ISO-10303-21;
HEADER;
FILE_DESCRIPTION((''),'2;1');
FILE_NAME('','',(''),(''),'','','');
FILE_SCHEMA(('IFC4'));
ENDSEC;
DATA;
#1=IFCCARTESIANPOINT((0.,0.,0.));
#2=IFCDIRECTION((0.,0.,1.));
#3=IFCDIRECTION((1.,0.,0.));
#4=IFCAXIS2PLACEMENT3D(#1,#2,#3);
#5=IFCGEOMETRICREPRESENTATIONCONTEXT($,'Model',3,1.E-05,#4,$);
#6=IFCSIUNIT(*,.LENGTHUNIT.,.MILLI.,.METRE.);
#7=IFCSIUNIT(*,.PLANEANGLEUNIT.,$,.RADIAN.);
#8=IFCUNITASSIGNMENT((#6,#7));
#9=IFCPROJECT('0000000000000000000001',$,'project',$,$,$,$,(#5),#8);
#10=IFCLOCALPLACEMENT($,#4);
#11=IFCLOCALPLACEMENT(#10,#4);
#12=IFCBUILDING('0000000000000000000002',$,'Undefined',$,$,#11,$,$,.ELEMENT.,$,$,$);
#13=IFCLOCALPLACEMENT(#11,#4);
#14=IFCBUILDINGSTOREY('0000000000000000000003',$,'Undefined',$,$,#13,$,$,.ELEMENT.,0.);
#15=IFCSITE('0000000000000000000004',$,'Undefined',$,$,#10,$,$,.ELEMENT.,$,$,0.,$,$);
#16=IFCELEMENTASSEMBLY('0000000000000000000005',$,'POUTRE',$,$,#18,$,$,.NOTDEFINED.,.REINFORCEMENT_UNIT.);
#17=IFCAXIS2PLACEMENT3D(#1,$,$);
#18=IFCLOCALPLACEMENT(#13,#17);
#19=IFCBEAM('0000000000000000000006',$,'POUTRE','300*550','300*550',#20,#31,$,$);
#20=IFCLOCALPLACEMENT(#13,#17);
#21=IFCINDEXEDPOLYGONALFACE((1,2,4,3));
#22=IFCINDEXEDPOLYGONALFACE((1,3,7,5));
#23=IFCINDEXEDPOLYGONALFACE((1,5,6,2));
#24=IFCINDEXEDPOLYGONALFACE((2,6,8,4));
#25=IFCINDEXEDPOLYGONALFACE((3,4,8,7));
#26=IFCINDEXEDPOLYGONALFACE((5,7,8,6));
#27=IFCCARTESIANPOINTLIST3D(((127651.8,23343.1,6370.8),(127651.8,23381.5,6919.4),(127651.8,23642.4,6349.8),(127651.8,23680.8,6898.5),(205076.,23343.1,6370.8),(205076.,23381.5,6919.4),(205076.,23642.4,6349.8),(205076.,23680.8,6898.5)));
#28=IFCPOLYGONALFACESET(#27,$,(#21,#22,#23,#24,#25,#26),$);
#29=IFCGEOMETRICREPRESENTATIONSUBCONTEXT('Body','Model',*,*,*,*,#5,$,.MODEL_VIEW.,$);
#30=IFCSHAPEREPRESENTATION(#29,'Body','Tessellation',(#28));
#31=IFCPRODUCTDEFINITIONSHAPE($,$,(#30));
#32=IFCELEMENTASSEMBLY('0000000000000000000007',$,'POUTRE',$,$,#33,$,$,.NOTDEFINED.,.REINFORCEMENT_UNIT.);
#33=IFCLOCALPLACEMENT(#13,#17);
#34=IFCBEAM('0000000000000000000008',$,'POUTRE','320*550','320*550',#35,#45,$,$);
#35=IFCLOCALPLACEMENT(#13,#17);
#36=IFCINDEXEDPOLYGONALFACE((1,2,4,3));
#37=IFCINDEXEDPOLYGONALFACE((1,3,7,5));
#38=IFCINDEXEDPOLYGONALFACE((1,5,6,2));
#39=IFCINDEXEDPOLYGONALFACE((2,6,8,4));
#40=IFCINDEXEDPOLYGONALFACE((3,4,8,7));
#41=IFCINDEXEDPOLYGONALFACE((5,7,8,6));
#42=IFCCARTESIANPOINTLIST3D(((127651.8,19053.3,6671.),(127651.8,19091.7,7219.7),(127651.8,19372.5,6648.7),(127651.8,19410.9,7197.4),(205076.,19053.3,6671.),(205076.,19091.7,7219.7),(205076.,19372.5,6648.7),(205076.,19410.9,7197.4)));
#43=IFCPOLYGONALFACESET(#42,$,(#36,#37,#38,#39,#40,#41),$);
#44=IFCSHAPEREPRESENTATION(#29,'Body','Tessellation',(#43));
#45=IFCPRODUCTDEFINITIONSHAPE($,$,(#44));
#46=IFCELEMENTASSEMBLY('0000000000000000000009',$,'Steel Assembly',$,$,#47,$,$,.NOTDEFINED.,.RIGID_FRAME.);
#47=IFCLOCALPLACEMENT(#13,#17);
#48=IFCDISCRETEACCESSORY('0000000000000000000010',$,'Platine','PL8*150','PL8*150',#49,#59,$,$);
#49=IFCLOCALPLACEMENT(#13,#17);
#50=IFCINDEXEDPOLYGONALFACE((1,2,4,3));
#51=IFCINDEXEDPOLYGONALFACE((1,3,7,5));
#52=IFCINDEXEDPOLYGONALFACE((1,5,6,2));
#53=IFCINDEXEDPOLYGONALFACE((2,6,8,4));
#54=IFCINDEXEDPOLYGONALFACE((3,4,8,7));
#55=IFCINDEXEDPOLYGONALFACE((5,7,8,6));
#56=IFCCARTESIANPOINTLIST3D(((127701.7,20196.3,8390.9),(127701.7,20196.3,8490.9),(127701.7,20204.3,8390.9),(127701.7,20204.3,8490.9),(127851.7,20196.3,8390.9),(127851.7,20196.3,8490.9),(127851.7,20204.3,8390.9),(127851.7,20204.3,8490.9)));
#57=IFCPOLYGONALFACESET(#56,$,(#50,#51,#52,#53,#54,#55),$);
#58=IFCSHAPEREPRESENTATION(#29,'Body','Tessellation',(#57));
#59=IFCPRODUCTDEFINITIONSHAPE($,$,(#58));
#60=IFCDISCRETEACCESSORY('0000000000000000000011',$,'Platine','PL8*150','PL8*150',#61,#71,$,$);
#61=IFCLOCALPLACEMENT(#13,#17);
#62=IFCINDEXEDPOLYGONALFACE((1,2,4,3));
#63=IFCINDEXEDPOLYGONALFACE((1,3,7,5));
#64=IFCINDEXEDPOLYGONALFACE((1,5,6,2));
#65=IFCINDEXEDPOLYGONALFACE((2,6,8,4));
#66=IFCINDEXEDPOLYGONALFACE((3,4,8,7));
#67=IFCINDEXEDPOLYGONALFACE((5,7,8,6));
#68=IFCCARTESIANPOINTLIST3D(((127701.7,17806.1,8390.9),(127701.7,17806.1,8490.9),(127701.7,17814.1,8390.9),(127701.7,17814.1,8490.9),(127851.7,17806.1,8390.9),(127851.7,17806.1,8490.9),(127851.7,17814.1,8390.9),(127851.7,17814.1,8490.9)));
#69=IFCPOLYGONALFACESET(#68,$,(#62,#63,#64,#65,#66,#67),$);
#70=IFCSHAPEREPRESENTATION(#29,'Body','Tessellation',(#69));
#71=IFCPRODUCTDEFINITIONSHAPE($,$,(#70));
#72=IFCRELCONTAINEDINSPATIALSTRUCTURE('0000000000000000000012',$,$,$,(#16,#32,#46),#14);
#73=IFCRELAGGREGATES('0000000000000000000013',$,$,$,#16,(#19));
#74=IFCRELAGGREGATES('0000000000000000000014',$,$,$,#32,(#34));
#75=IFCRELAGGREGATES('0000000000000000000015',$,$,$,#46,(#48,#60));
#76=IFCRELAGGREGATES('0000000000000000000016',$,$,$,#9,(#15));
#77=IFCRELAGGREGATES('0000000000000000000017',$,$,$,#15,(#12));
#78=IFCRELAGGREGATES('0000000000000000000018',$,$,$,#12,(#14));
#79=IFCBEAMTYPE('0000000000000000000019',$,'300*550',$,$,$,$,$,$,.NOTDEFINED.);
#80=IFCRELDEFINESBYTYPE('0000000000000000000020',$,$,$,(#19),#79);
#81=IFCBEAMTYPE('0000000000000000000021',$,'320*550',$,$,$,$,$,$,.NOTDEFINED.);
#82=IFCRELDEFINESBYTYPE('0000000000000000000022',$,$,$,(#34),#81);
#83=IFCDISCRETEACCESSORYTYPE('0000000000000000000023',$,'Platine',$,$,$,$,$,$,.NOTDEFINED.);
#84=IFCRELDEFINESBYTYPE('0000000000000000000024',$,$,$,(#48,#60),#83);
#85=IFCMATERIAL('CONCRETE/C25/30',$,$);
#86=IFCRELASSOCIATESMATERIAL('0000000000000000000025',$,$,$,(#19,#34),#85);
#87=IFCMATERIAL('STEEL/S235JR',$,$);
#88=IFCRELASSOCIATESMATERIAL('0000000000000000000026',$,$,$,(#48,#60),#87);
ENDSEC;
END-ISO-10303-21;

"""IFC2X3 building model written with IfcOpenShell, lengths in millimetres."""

from ifc_helpers import new_model, si_unit, frame, origin_with_axes, origin_2d_with_axis, place, context, subcontext, project, spatial, polyline, rectangle, outline, extrude, material, type_object, element, aggregate, save


model = new_model("IFC2X3")

# Units and contexts
model_context = context("Model", 3, precision=1e-05, world=origin_with_axes())
body_context = subcontext(model_context, "Body", "Model", "MODEL_VIEW")
ifc_project = project(units=[si_unit("LENGTHUNIT", "METRE", prefix="MILLI"), si_unit("PLANEANGLEUNIT", "RADIAN")], contexts=[model_context])

# Site, building, storey
site_placement = place(None, origin_with_axes())
site = spatial("IfcSite", under=ifc_project, at=site_placement, Name="Undefined", CompositionType="ELEMENT", RefElevation=0.0)
building_placement = place(site_placement, origin_with_axes())
building = spatial("IfcBuilding", under=site, at=building_placement, Name="Undefined", CompositionType="ELEMENT")
storey_placement = place(building_placement, origin_with_axes())
storey = spatial("IfcBuildingStorey", under=building, at=storey_placement, Name="Undefined", CompositionType="ELEMENT", Elevation=0.0)

# Shared definitions
ifc_material_1 = material(Name="CONCRETE/C25/30")

# Element assemblies, beams
assembly_1_placement = place(storey_placement, origin_with_axes())
assembly_1 = element("IfcElementAssembly", 1, at=assembly_1_placement, inside=storey, Name="POUTRE", AssemblyPlace="NOTDEFINED", PredefinedType="REINFORCEMENT_UNIT")
beam_type_1 = type_object("IfcBeamType", Name="300*550", PredefinedType="NOTDEFINED")
beam_1_placement = place(assembly_1_placement, frame((127776.7, 23512.0, 6634.6), z_axis=(0.0, -0.997559, 0.069829), x_axis=(1.0, 0.0, 0.0)))
beam_1 = element("IfcBeam", 2, at=beam_1_placement, type_object=beam_type_1, material=ifc_material_1, Name="POUTRE", Description="300*550", ObjectType="300*550", context=body_context, shape_type="SweptSolid", body=[
    extrude(rectangle(XDim=550.0, YDim=300.0, at=origin_2d_with_axis()), frame((77299.3, 0.0, 0.0), z_axis=(-1.0, 0.0, 0.0), x_axis=(0.0, -1.0, 0.0)), (0.0, 0.0, 1.0), 77424.2),
])
aggregate(assembly_1, [beam_1])
assembly_2_placement = place(storey_placement, origin_with_axes())
assembly_2 = element("IfcElementAssembly", 3, at=assembly_2_placement, inside=storey, Name="POUTRE", AssemblyPlace="NOTDEFINED", PredefinedType="REINFORCEMENT_UNIT")
beam_type_2 = type_object("IfcBeamType", Name="320*550", PredefinedType="NOTDEFINED")
beam_2_placement = place(assembly_2_placement, frame((127776.7, 19232.1, 6934.2), z_axis=(0.0, -0.997559, 0.069829), x_axis=(1.0, 0.0, 0.0)))
beam_2 = element("IfcBeam", 4, at=beam_2_placement, type_object=beam_type_2, material=ifc_material_1, Name="POUTRE", Description="320*550", ObjectType="320*550", context=body_context, shape_type="SweptSolid", body=[
    extrude(rectangle(XDim=550.0, YDim=320.0, at=origin_2d_with_axis()), frame((77299.3, 0.0, 0.0), z_axis=(-1.0, 0.0, 0.0), x_axis=(0.0, -1.0, 0.0)), (0.0, 0.0, 1.0), 77424.2),
])
aggregate(assembly_2, [beam_2])

# Element assembly, discrete accessories
assembly_3_placement = place(storey_placement, origin_with_axes())
assembly_3 = element("IfcElementAssembly", 5, at=assembly_3_placement, inside=storey, Name="Steel Assembly", AssemblyPlace="NOTDEFINED", PredefinedType="RIGID_FRAME")
ifc_material_2 = material(Name="STEEL/S235JR")
discrete_accessory_type_1 = type_object("IfcDiscreteAccessoryType", Name="Platine")
discrete_accessory_1_placement = place(assembly_3_placement, frame((127776.7, 20200.3, 8390.9), z_axis=(0.0, -1.0, 0.0), x_axis=(0.0, 0.0, 1.0)))
discrete_accessory_1 = element("IfcDiscreteAccessory", 6, at=discrete_accessory_1_placement, type_object=discrete_accessory_type_1, material=ifc_material_2, Name="Platine", Description="PL8*150", ObjectType="PL8*150", context=body_context, shape_type="SweptSolid", body=[
    extrude(outline(polyline([(100.0, 75.0), (100.0, -75.0), (0.0, -75.0), (0.0, 75.0), (100.0, 75.0)])), frame((0.0, 0.0, -4.0), z_axis=(0.0, 0.0, 1.0), x_axis=(1.0, 0.0, 0.0)), (0.0, 0.0, 1.0), 8.0),
])
discrete_accessory_2_placement = place(assembly_3_placement, frame((127776.7, 17810.1, 8390.9), z_axis=(0.000002, 1.0, 0.0), x_axis=(0.0, 0.0, 1.0)))
discrete_accessory_2 = element("IfcDiscreteAccessory", 7, at=discrete_accessory_2_placement, type_object=discrete_accessory_type_1, material=ifc_material_2, Name="Platine", Description="PL8*150", ObjectType="PL8*150", context=body_context, shape_type="SweptSolid", body=[
    extrude(outline(polyline([(0.0, 75.0), (100.0, 75.0), (100.0, -75.0), (0.0, -75.0), (0.0, 75.0)])), frame((0.0, 0.0, -4.0), z_axis=(0.0, 0.0, 1.0), x_axis=(1.0, 0.0, 0.0)), (0.0, 0.0, 1.0), 8.0),
])
aggregate(assembly_3, [discrete_accessory_1, discrete_accessory_2])

save(model, "model.ifc")
